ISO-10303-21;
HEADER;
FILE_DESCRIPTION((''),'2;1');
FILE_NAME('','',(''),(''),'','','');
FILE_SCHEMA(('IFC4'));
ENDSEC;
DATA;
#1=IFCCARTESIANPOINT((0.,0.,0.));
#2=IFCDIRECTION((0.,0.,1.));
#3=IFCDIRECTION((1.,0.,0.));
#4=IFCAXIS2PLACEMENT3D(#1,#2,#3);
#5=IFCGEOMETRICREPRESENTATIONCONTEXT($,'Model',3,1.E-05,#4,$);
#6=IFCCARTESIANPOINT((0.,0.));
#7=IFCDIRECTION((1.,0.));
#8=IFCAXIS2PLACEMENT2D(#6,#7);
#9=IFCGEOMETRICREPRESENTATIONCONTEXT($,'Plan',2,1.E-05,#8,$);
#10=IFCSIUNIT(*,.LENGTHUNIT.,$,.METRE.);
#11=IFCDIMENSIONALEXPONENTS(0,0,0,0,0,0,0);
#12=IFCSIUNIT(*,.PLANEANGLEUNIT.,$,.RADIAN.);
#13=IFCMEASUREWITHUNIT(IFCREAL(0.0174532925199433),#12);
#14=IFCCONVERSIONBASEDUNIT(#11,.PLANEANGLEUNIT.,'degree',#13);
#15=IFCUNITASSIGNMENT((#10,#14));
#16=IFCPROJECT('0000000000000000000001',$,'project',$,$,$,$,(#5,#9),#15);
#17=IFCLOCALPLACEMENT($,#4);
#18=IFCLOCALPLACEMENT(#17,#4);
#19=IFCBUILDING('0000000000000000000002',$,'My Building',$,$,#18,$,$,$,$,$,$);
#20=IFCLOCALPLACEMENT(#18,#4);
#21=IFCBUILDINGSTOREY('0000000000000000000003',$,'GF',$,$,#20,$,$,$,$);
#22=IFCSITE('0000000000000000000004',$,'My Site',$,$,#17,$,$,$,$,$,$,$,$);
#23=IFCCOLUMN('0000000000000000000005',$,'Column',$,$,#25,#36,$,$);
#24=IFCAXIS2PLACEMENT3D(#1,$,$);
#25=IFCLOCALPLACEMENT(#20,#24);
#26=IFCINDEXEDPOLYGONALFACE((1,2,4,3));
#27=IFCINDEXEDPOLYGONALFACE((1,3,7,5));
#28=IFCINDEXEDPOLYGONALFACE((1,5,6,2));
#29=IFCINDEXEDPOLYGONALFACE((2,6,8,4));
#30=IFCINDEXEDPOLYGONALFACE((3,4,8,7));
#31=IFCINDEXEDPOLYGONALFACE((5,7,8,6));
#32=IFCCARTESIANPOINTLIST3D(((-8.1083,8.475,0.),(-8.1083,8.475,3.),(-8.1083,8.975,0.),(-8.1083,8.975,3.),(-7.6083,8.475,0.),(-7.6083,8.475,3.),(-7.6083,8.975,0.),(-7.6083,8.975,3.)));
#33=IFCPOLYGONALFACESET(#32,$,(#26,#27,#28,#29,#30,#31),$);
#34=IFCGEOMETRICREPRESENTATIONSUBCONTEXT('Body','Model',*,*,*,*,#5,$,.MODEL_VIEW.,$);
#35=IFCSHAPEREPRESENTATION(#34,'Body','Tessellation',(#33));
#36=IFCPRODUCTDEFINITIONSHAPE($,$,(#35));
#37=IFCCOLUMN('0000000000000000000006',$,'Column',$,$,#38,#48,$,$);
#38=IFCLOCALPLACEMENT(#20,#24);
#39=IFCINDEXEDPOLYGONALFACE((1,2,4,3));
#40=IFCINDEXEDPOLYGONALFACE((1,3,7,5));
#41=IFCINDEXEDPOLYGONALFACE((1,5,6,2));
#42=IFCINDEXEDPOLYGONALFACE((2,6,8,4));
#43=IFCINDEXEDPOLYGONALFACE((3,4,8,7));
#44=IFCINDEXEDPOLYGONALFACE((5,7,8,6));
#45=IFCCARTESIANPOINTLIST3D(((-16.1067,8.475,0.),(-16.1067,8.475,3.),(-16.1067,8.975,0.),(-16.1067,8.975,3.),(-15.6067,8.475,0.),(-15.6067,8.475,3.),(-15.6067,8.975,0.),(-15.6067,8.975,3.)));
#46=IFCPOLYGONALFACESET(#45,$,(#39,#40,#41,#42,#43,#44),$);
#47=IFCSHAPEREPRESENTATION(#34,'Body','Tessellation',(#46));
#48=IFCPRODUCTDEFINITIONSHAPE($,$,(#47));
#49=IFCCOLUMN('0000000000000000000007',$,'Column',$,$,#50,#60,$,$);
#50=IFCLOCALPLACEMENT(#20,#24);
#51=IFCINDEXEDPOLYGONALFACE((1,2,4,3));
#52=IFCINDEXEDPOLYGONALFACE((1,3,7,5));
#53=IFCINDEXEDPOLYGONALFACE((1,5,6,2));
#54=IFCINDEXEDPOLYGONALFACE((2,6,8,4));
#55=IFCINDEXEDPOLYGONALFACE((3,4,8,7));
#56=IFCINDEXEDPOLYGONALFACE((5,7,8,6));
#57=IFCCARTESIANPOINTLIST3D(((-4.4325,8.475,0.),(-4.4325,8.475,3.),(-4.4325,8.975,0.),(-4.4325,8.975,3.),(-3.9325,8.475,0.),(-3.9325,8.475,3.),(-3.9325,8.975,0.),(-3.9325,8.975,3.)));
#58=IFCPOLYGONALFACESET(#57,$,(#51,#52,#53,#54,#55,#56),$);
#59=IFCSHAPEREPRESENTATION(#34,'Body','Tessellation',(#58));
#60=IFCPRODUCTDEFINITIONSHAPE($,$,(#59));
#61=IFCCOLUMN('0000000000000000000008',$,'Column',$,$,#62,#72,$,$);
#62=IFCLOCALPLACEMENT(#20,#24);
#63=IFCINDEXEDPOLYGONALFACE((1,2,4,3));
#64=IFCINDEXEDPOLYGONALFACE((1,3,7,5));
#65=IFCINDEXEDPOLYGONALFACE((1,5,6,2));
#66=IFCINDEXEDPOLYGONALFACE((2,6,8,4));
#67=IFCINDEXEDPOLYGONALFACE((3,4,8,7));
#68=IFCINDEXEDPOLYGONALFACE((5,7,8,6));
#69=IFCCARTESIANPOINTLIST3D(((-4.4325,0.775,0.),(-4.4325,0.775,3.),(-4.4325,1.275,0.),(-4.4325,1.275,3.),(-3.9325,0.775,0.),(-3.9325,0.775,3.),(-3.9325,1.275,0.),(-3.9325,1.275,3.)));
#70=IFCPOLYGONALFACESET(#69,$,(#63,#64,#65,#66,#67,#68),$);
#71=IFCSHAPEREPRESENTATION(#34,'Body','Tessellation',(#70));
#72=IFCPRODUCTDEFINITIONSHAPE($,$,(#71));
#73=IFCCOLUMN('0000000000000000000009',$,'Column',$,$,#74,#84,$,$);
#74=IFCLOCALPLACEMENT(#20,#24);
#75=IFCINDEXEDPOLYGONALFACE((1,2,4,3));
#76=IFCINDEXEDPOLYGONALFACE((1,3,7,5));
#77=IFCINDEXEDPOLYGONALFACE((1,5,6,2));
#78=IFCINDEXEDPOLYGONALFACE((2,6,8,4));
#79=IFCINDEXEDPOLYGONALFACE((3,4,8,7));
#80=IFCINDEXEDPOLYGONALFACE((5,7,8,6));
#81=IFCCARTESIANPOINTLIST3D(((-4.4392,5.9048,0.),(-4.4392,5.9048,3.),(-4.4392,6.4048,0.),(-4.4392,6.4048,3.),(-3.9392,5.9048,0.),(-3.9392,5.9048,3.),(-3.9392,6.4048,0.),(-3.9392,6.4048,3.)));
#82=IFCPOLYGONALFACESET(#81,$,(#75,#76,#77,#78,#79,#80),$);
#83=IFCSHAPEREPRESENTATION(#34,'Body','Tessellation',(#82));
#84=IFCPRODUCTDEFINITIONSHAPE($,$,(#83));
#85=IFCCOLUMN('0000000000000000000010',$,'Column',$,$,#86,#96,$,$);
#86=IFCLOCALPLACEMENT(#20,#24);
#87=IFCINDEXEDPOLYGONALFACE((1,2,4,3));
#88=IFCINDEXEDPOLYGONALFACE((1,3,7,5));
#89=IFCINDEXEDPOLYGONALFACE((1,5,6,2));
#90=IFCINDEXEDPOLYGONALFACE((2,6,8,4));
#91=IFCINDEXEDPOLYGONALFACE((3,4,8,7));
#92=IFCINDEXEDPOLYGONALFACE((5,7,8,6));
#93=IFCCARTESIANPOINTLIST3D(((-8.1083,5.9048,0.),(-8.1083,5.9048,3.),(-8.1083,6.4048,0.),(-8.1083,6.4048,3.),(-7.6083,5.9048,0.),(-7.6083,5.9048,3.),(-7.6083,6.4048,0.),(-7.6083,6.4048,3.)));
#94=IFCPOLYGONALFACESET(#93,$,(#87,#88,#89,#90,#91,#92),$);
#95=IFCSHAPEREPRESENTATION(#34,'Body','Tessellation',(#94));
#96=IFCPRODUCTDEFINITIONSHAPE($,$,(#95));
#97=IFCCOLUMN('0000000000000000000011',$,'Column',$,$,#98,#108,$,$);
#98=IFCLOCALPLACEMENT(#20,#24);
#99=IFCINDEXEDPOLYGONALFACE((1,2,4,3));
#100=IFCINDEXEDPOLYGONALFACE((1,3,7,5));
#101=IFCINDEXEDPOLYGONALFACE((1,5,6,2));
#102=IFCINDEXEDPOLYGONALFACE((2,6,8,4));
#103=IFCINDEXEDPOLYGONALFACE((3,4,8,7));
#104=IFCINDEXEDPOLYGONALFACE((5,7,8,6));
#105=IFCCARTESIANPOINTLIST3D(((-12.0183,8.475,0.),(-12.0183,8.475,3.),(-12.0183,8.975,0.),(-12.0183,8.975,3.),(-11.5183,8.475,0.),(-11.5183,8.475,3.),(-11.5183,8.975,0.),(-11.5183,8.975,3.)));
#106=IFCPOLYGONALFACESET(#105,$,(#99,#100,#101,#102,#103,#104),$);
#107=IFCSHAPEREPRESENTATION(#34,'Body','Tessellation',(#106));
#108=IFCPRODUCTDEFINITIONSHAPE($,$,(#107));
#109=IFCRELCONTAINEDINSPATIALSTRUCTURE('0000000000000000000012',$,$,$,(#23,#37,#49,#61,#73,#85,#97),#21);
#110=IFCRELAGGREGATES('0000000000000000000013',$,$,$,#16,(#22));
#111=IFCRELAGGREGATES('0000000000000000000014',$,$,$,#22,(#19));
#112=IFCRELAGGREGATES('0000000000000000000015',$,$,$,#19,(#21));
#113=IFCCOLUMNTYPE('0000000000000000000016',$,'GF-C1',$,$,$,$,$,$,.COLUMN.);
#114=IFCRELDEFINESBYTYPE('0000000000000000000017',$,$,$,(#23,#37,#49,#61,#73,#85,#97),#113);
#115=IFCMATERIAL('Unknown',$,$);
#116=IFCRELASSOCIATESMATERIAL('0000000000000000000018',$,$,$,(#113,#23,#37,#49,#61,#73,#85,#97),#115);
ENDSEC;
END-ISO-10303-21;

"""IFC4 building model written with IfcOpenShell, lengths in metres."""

from ifc_helpers import new_model, entity, si_unit, converted_unit, frame, origin_with_axes, origin_2d_with_axis, place, context, subcontext, project, spatial, rectangle, extrude, material, material_profile, profile_set, profile_usage, type_object, element, save


model = new_model("IFC4")

# Units and contexts
model_context = context("Model", 3, precision=1e-05, world=origin_with_axes())
plan_context = context("Plan", 2, precision=1e-05, world=origin_2d_with_axis())
body_context_1 = subcontext(model_context, "Body", "Model", "MODEL_VIEW")
ifc_project = project(units=[si_unit("LENGTHUNIT", "METRE"), converted_unit("PLANEANGLEUNIT", "degree", entity("IfcReal", 0.0174532925199433), si_unit("PLANEANGLEUNIT", "RADIAN"), dimensions=[0, 0, 0, 0, 0, 0, 0])], contexts=[model_context, plan_context])

# Site, building, storey
site_placement = place(None, origin_with_axes())
site = spatial("IfcSite", under=ifc_project, at=site_placement, Name="My Site")
building_placement = place(site_placement, origin_with_axes())
building = spatial("IfcBuilding", under=site, at=building_placement, Name="My Building")
storey_placement = place(building_placement, origin_with_axes())
storey = spatial("IfcBuildingStorey", under=building, at=storey_placement, Name="GF")

# Columns
ifc_material = material(Name="Unknown")
ifc_material_profile = material_profile(ifc_material, rectangle(XDim=0.5, YDim=0.5))
ifc_profile_set = profile_set([ifc_material_profile])
ifc_profile_usage_1 = profile_usage(ifc_profile_set, cardinal=9)
column_type = type_object("IfcColumnType", Name="GF-C1", PredefinedType="COLUMN", material=ifc_profile_set)
column_1_placement = place(storey_placement, frame((-8.1083, 8.975, 0.0), z_axis=(0.0, 0.0, 1.0), x_axis=(1.0, 0.0, 0.0)))
element("IfcColumn", 1, at=column_1_placement, inside=storey, type_object=column_type, material=ifc_profile_usage_1, Name="Column", context=body_context_1, shape_type="SweptSolid", body=[
    extrude(rectangle(XDim=0.5, YDim=0.5), frame((0.25, -0.25, 0.0), z_axis=(0.0, 0.0, 1.0), x_axis=(1.0, 0.0, 0.0)), (0.0, 0.0, 1.0), 3.0),
])
ifc_profile_usage_2 = profile_usage(ifc_profile_set, cardinal=7)
column_2_placement = place(storey_placement, frame((-15.6067, 8.975, 0.0), z_axis=(0.0, 0.0, 1.0), x_axis=(1.0, 0.0, 0.0)))
element("IfcColumn", 2, at=column_2_placement, inside=storey, type_object=column_type, material=ifc_profile_usage_2, Name="Column", context=body_context_1, shape_type="SweptSolid", body=[
    extrude(rectangle(XDim=0.5, YDim=0.5), frame((-0.25, -0.25, 0.0), z_axis=(0.0, 0.0, 1.0), x_axis=(1.0, 0.0, 0.0)), (0.0, 0.0, 1.0), 3.0),
])
ifc_profile_usage_3 = profile_usage(ifc_profile_set, cardinal=7)
column_3_placement = place(storey_placement, frame((-3.9325, 8.975, 0.0), z_axis=(0.0, 0.0, 1.0), x_axis=(1.0, 0.0, 0.0)))
element("IfcColumn", 3, at=column_3_placement, inside=storey, type_object=column_type, material=ifc_profile_usage_3, Name="Column", context=body_context_1, shape_type="SweptSolid", body=[
    extrude(rectangle(XDim=0.5, YDim=0.5), frame((-0.25, -0.25, 0.0), z_axis=(0.0, 0.0, 1.0), x_axis=(1.0, 0.0, 0.0)), (0.0, 0.0, 1.0), 3.0),
])
ifc_profile_usage_4 = profile_usage(ifc_profile_set, cardinal=1)
column_4_placement = place(storey_placement, frame((-3.9325, 0.775, 0.0), z_axis=(0.0, 0.0, 1.0), x_axis=(1.0, 0.0, 0.0)))
element("IfcColumn", 4, at=column_4_placement, inside=storey, type_object=column_type, material=ifc_profile_usage_4, Name="Column", context=body_context_1, shape_type="SweptSolid", body=[
    extrude(rectangle(XDim=0.5, YDim=0.5), frame((-0.25, 0.25, 0.0), z_axis=(0.0, 0.0, 1.0), x_axis=(1.0, 0.0, 0.0)), (0.0, 0.0, 1.0), 3.0),
])
ifc_profile_usage_5 = profile_usage(ifc_profile_set, cardinal=1)
column_5_placement = place(storey_placement, frame((-3.9392, 5.9048, 0.0), z_axis=(0.0, 0.0, 1.0), x_axis=(1.0, 0.0, 0.0)))
element("IfcColumn", 5, at=column_5_placement, inside=storey, type_object=column_type, material=ifc_profile_usage_5, Name="Column", context=body_context_1, shape_type="SweptSolid", body=[
    extrude(rectangle(XDim=0.5, YDim=0.5), frame((-0.25, 0.25, 0.0), z_axis=(0.0, 0.0, 1.0), x_axis=(1.0, 0.0, 0.0)), (0.0, 0.0, 1.0), 3.0),
])
ifc_profile_usage_6 = profile_usage(ifc_profile_set, cardinal=3)
column_6_placement = place(storey_placement, frame((-8.1083, 5.9048, 0.0), z_axis=(0.0, 0.0, 1.0), x_axis=(1.0, 0.0, 0.0)))
element("IfcColumn", 6, at=column_6_placement, inside=storey, type_object=column_type, material=ifc_profile_usage_6, Name="Column", context=body_context_1, shape_type="SweptSolid", body=[
    extrude(rectangle(XDim=0.5, YDim=0.5), frame((0.25, 0.25, 0.0), z_axis=(0.0, 0.0, 1.0), x_axis=(1.0, 0.0, 0.0)), (0.0, 0.0, 1.0), 3.0),
])
ifc_profile_usage_7 = profile_usage(ifc_profile_set, cardinal=8)
column_7_placement = place(storey_placement, frame((-11.7683, 8.975, 0.0), z_axis=(0.0, 0.0, 1.0), x_axis=(1.0, 0.0, 0.0)))
element("IfcColumn", 7, at=column_7_placement, inside=storey, type_object=column_type, material=ifc_profile_usage_7, Name="Column", context=body_context_1, shape_type="SweptSolid", body=[
    extrude(rectangle(XDim=0.5, YDim=0.5), frame((0.0, -0.25, 0.0), z_axis=(0.0, 0.0, 1.0), x_axis=(1.0, 0.0, 0.0)), (0.0, 0.0, 1.0), 3.0),
])

save(model, "model.ifc")
